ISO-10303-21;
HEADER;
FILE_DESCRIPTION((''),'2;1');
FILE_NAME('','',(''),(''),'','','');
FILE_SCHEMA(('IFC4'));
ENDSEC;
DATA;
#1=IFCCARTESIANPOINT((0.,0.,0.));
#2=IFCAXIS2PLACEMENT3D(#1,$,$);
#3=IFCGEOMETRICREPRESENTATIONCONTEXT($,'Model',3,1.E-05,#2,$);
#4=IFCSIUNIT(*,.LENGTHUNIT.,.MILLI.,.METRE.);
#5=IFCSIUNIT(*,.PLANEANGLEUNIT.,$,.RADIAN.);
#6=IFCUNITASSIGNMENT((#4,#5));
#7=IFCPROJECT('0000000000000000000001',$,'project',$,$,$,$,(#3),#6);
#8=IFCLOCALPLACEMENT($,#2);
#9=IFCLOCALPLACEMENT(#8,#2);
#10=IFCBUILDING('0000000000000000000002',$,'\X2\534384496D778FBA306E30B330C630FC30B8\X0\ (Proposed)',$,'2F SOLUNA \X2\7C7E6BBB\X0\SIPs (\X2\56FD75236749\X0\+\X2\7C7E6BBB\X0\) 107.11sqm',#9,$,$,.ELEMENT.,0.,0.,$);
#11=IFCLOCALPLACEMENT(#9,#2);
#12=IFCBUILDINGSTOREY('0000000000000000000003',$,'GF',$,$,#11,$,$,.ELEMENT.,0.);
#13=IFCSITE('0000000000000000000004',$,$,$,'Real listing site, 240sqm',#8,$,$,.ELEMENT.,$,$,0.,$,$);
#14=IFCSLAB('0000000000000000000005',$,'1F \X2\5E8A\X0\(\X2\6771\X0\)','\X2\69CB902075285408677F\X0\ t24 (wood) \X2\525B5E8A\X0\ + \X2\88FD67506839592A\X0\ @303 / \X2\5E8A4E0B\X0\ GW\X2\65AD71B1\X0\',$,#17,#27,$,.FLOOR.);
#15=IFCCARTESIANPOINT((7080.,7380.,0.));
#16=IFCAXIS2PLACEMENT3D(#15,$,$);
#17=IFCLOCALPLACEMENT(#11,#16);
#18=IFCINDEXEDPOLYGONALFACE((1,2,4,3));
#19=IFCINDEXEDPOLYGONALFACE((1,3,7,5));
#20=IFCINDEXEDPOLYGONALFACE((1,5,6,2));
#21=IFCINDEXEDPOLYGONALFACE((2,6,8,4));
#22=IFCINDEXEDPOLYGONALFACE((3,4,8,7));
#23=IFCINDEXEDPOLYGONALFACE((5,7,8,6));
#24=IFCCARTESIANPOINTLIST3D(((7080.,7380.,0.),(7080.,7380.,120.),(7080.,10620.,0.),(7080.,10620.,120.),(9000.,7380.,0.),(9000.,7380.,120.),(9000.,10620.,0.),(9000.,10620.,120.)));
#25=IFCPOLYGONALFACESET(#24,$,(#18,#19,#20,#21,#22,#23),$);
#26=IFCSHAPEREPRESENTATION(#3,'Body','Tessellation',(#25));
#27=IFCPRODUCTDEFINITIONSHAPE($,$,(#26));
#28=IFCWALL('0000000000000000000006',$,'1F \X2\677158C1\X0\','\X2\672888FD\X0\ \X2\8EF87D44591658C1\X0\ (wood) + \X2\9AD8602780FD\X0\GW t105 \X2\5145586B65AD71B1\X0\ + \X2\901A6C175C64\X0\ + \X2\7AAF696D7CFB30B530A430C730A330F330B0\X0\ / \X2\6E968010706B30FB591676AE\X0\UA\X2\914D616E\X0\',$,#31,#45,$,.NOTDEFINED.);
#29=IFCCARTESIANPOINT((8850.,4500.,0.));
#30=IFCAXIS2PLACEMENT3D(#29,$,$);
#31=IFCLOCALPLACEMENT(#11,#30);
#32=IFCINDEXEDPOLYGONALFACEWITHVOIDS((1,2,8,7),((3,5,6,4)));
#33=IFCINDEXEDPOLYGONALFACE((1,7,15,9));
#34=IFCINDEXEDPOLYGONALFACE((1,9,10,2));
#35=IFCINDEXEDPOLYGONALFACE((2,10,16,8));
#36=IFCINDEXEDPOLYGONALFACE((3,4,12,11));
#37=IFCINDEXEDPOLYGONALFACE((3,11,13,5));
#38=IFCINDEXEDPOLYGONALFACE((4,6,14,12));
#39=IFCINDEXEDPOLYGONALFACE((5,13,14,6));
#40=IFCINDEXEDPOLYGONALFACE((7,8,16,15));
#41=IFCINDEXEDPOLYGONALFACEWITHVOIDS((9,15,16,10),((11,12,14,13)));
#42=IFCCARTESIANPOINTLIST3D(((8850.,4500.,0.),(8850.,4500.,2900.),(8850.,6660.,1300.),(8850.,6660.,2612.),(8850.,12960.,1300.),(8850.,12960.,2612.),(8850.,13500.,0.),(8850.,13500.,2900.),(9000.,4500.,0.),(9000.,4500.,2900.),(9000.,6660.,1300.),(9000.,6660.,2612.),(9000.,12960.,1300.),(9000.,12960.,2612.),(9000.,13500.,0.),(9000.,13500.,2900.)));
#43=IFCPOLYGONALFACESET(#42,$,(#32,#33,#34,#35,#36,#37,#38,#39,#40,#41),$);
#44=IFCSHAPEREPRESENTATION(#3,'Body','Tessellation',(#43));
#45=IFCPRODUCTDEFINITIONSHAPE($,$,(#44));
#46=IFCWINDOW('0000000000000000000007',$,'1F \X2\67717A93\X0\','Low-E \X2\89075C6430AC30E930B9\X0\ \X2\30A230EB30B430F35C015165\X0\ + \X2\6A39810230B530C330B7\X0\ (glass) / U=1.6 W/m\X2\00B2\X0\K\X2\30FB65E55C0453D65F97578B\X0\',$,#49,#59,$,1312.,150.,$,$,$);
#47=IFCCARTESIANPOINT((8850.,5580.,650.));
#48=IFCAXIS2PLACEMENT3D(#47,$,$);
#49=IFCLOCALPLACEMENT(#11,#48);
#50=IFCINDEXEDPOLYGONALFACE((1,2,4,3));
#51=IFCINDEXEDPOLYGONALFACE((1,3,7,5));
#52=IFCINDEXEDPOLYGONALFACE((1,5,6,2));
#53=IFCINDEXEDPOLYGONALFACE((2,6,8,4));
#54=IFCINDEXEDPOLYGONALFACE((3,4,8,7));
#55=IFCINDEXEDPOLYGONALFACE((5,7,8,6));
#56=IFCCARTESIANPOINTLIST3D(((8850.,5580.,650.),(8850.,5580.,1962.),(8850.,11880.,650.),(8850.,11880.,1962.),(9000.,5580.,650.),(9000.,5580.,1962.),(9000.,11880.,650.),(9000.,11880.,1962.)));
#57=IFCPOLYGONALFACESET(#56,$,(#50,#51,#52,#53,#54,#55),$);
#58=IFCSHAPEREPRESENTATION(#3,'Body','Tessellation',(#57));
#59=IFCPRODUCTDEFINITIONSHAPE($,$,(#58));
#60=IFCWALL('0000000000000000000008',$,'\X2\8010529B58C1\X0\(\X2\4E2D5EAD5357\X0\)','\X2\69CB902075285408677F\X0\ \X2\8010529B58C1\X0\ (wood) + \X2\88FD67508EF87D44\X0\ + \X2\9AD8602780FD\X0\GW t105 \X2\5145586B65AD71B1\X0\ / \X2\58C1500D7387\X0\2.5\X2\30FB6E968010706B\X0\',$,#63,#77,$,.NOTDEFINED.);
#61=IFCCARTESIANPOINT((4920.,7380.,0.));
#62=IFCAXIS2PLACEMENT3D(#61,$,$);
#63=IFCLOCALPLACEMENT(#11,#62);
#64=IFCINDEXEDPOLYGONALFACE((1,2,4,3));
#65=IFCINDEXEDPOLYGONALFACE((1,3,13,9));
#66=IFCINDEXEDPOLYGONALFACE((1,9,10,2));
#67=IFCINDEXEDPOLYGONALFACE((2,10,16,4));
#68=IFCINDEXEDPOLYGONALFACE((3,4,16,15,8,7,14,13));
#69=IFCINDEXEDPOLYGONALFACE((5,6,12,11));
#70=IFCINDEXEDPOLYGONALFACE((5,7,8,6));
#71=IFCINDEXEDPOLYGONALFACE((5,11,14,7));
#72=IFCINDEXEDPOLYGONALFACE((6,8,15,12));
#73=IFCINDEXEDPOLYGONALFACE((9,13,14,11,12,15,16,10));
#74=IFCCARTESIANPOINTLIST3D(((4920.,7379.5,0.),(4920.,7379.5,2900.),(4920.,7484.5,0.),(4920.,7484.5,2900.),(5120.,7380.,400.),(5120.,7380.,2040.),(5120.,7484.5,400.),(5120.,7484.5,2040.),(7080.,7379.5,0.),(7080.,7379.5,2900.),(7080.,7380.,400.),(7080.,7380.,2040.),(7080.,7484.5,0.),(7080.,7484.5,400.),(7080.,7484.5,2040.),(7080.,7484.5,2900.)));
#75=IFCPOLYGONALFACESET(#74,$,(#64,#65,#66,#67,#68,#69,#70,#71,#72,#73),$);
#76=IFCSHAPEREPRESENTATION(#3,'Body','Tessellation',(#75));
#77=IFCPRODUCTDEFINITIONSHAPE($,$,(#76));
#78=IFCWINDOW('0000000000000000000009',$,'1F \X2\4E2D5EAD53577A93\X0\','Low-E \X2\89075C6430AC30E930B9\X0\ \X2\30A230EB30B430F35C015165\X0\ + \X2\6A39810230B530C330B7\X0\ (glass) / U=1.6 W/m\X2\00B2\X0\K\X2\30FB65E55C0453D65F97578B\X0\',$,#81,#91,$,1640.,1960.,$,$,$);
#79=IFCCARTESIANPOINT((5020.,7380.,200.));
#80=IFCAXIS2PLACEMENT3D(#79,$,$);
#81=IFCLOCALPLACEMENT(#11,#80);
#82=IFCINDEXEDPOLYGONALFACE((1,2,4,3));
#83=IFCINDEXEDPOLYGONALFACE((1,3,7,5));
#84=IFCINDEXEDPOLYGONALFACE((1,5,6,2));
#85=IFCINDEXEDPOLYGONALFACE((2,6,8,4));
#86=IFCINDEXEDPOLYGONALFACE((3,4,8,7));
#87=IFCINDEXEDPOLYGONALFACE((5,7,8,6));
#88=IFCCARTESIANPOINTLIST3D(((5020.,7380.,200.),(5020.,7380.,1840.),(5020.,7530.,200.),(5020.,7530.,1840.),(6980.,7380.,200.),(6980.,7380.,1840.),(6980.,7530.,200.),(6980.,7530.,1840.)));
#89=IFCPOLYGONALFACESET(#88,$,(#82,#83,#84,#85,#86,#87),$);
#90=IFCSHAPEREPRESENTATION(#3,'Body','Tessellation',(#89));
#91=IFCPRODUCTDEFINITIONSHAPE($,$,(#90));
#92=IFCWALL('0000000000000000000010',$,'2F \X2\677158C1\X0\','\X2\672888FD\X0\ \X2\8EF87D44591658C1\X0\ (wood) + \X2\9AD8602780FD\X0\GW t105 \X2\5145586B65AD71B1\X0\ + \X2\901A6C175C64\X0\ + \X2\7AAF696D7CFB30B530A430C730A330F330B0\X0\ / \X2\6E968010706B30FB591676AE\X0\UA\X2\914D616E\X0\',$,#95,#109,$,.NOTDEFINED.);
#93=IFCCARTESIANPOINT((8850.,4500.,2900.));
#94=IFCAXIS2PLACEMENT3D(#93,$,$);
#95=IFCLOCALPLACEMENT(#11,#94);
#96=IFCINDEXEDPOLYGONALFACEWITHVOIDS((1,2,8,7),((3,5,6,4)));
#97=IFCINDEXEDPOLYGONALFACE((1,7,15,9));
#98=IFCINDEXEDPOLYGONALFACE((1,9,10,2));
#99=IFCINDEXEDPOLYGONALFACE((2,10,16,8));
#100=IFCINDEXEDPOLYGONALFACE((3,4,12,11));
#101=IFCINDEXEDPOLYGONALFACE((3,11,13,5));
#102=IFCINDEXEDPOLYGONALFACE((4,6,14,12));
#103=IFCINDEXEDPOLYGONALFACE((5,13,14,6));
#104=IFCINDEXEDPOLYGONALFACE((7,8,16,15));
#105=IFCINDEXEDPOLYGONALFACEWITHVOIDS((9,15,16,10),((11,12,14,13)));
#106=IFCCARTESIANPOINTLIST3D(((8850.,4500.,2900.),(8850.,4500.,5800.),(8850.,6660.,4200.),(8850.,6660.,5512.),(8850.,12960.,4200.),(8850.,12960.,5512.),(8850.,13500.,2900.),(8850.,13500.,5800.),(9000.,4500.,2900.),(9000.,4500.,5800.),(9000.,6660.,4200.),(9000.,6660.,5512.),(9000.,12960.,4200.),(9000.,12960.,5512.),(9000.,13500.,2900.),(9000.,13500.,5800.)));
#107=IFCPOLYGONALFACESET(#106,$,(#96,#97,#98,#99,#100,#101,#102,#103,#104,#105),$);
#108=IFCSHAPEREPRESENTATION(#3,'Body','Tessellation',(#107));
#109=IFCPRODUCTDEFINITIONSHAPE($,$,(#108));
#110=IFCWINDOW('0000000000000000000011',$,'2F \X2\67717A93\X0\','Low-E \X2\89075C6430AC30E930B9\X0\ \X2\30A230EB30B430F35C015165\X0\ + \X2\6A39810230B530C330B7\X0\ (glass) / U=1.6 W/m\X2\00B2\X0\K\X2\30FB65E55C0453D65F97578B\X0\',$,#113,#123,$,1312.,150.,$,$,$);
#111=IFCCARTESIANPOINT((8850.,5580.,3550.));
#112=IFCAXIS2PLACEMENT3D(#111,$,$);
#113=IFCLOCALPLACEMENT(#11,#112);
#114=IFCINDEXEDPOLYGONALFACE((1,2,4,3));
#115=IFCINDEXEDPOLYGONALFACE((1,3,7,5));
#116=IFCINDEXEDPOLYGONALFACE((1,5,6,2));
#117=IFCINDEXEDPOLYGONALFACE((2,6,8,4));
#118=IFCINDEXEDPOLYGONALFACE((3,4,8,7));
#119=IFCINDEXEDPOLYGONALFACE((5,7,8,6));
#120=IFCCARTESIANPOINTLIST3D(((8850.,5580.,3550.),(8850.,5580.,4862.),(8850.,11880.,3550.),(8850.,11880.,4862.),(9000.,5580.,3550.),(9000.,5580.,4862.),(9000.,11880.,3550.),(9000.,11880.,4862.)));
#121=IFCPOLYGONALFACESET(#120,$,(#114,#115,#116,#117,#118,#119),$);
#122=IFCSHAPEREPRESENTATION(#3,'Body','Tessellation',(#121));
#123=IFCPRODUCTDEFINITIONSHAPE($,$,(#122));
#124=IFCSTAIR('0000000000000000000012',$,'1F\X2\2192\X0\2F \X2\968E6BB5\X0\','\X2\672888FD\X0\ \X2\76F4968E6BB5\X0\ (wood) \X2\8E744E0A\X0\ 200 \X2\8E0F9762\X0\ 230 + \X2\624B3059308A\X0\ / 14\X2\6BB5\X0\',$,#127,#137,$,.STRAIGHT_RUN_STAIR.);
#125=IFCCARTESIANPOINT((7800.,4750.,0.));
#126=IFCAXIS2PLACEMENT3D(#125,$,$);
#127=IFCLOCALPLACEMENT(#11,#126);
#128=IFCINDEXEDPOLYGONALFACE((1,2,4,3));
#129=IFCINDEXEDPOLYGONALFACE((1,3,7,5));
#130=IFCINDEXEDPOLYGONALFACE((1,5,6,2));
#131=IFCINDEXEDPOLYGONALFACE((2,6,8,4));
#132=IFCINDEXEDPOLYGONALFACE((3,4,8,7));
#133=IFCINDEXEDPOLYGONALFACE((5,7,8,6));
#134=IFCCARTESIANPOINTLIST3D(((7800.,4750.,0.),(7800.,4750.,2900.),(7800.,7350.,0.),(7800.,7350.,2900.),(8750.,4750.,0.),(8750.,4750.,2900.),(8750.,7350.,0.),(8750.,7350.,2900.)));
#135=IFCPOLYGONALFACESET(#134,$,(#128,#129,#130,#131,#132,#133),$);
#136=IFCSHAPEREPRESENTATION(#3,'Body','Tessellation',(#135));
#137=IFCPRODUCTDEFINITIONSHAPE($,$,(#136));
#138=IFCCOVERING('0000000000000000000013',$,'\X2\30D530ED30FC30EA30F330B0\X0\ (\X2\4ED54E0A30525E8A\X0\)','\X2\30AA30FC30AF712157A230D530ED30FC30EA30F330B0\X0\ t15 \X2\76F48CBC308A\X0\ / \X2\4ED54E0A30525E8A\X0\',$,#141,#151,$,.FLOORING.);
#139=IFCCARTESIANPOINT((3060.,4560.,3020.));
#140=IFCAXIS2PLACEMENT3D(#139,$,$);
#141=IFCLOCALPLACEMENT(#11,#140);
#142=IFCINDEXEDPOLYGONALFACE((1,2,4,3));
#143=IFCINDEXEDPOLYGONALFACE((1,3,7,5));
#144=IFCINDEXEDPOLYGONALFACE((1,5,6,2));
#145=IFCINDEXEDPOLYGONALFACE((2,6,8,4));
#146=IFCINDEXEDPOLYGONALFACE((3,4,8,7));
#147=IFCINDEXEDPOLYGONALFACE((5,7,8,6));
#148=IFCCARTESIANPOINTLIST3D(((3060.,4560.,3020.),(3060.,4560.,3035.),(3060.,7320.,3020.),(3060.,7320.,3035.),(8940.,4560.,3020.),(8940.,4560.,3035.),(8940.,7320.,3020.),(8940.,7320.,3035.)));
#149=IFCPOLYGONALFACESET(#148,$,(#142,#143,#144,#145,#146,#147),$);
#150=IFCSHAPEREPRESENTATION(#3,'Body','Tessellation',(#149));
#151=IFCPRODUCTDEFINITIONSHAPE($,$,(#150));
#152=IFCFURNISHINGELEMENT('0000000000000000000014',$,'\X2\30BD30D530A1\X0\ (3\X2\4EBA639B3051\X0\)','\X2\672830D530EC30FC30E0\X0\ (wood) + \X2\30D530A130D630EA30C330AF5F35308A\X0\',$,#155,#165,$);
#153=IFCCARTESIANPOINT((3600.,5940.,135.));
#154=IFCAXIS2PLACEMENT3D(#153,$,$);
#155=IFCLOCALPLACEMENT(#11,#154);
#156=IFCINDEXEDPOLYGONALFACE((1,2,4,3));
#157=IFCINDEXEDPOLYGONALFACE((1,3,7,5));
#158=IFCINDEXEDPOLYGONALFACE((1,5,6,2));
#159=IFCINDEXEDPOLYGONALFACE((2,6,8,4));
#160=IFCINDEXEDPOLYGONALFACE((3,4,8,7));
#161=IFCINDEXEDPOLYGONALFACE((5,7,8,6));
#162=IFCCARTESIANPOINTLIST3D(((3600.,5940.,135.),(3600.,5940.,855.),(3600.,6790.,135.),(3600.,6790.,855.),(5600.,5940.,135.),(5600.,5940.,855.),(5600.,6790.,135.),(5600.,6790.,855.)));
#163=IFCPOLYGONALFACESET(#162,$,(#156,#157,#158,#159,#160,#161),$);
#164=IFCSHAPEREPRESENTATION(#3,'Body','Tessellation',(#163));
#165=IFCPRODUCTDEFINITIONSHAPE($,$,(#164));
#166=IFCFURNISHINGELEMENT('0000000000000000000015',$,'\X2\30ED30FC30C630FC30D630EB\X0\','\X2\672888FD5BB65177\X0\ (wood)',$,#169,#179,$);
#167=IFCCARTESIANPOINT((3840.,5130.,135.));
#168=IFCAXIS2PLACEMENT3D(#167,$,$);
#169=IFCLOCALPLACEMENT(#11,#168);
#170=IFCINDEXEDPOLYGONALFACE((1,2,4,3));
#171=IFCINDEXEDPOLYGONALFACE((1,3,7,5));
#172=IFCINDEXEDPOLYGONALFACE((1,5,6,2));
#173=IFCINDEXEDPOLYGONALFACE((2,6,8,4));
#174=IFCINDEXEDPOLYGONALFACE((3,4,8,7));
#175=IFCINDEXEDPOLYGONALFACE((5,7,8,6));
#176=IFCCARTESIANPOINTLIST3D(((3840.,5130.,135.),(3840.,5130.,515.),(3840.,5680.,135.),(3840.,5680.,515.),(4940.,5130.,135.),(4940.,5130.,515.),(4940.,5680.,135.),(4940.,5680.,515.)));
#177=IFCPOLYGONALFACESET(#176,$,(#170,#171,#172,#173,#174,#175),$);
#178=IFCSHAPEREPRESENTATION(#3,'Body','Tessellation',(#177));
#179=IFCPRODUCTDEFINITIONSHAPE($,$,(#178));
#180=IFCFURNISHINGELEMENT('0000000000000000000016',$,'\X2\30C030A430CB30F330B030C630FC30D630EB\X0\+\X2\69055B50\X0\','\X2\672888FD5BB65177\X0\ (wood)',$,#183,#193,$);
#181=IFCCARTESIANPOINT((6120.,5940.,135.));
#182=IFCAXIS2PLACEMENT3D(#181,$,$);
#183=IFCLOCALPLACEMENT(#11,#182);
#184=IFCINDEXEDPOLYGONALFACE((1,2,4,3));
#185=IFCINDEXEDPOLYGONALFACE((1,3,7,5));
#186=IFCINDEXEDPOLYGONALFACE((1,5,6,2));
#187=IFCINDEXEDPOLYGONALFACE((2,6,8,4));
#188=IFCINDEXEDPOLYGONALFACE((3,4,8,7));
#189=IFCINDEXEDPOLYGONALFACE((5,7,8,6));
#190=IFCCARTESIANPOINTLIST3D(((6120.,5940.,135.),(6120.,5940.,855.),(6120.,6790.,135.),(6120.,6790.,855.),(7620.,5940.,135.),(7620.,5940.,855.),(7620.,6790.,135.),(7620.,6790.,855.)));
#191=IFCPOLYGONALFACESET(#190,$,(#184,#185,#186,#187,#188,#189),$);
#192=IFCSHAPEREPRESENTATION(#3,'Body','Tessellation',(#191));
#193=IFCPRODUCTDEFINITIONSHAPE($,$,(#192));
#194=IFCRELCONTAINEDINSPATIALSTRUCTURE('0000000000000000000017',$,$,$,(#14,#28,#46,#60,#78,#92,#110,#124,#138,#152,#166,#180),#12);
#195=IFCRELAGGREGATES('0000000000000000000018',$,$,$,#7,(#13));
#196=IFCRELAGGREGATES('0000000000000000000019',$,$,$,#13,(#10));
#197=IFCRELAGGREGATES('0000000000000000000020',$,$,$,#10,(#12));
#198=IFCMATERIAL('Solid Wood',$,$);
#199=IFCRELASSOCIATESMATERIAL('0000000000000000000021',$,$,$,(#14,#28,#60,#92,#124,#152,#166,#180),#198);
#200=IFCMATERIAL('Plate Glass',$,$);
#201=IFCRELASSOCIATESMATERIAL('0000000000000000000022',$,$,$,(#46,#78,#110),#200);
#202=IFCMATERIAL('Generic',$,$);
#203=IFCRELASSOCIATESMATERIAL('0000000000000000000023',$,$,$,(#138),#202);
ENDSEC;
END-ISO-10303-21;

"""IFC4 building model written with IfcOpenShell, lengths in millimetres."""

from ifc_helpers import new_model, si_unit, frame, frame_2d, origin, place, context, project, spatial, rectangle, extrude, material, element, fill, save


model = new_model("IFC4")

# Units and contexts
model_context = context("Model", 3, precision=1e-05, world=origin())
ifc_project = project(units=[si_unit("LENGTHUNIT", "METRE", prefix="MILLI"), si_unit("PLANEANGLEUNIT", "RADIAN")], contexts=[model_context])

# Site, building, storey
site_placement = place(None, origin())
site = spatial("IfcSite", under=ifc_project, at=site_placement, ObjectType="Real listing site, 240sqm", CompositionType="ELEMENT", RefElevation=0.0)
building_placement = place(site_placement, origin())
building = spatial("IfcBuilding", under=site, at=building_placement, Name="千葉海辺のコテージ (Proposed)", ObjectType="2F SOLUNA 籾殻SIPs (国産杉+籾殻) 107.11sqm", CompositionType="ELEMENT", ElevationOfRefHeight=0.0, ElevationOfTerrain=0.0)
storey_placement = place(building_placement, origin())
storey = spatial("IfcBuildingStorey", under=building, at=storey_placement, Name="GF", CompositionType="ELEMENT", Elevation=0.0)

# Slab
ifc_material_1 = material(Name="Solid Wood")
slab_placement = place(storey_placement, frame((7080.0, 7380.0, 0.0)))
element("IfcSlab", 1, at=slab_placement, inside=storey, material=ifc_material_1, Name="1F 床(東)", Description="構造用合板 t24 (wood) 剛床 + 製材根太 @303 / 床下 GW断熱", PredefinedType="FLOOR", context=model_context, shape_type="SweptSolid", body=[
    extrude(rectangle(XDim=1920.0, YDim=3240.0, at=frame_2d((960.0, 1620.0))), frame((7080.0, 7380.0, 0.0)), (0.0, 0.0, 1.0), 120.0),
])

# Walls, openings, windows
wall_1_placement = place(storey_placement, frame((8850.0, 4500.0, 0.0)))
wall_1 = element("IfcWall", 2, at=wall_1_placement, inside=storey, material=ifc_material_1, Name="1F 東壁", Description="木製 軸組外壁 (wood) + 高性能GW t105 充填断熱 + 通気層 + 窯業系サイディング / 準耐火・外皮UA配慮", PredefinedType="NOTDEFINED", context=model_context, shape_type="SweptSolid", body=[
    extrude(rectangle(XDim=150.0, YDim=9000.0, at=frame_2d((75.0, 4500.0))), frame((8850.0, 4500.0, 0.0)), (0.0, 0.0, 1.0), 2900.0),
])
opening_1_placement = place(storey_placement, frame((8850.0, 5580.0, 650.0)))
opening_1 = element("IfcOpeningElement", 3, at=opening_1_placement, cuts=wall_1, PredefinedType="NOTDEFINED", context=model_context, shape_type="SweptSolid", body=[
    extrude(rectangle(XDim=150.0, YDim=6300.0, at=frame_2d((75.0, 3150.0))), frame((8850.0, 5580.0, 650.0)), (0.0, 0.0, 1.0), 1312.0),
])
ifc_material_2 = material(Name="Plate Glass")
window_1_placement = place(storey_placement, frame((8850.0, 5580.0, 650.0)))
window_1 = element("IfcWindow", 4, at=window_1_placement, inside=storey, material=ifc_material_2, Name="1F 東窓", Description="Low-E 複層ガラス アルゴン封入 + 樹脂サッシ (glass) / U=1.6 W/m²K・日射取得型", OverallHeight=1312.0, OverallWidth=150.0, context=model_context, shape_type="SweptSolid", body=[
    extrude(rectangle(XDim=150.0, YDim=6300.0, at=frame_2d((75.0, 3150.0))), frame((8850.0, 5580.0, 650.0)), (0.0, 0.0, 1.0), 1312.0),
])
fill(opening_1, window_1)
wall_2_placement = place(storey_placement, frame((4920.0, 7380.0, 0.0)))
wall_2 = element("IfcWall", 5, at=wall_2_placement, inside=storey, material=ifc_material_1, Name="耐力壁(中庭南)", Description="構造用合板 耐力壁 (wood) + 製材軸組 + 高性能GW t105 充填断熱 / 壁倍率2.5・準耐火", PredefinedType="NOTDEFINED", context=model_context, shape_type="SweptSolid", body=[
    extrude(rectangle(XDim=2160.0, YDim=105.0, at=frame_2d((1080.0, 52.0))), frame((4920.0, 7380.0, 0.0)), (0.0, 0.0, 1.0), 2900.0),
])
opening_2_placement = place(storey_placement, frame((5020.0, 7380.0, 200.0)))
opening_2 = element("IfcOpeningElement", 6, at=opening_2_placement, cuts=wall_2, PredefinedType="NOTDEFINED", context=model_context, shape_type="SweptSolid", body=[
    extrude(rectangle(XDim=1960.0, YDim=150.0, at=frame_2d((980.0, 75.0))), frame((5020.0, 7380.0, 200.0)), (0.0, 0.0, 1.0), 1640.0),
])
window_2_placement = place(storey_placement, frame((5020.0, 7380.0, 200.0)))
window_2 = element("IfcWindow", 7, at=window_2_placement, inside=storey, material=ifc_material_2, Name="1F 中庭南窓", Description="Low-E 複層ガラス アルゴン封入 + 樹脂サッシ (glass) / U=1.6 W/m²K・日射取得型", OverallHeight=1640.0, OverallWidth=1960.0, context=model_context, shape_type="SweptSolid", body=[
    extrude(rectangle(XDim=1960.0, YDim=150.0, at=frame_2d((980.0, 75.0))), frame((5020.0, 7380.0, 200.0)), (0.0, 0.0, 1.0), 1640.0),
])
fill(opening_2, window_2)

# Wall, opening, window
wall_3_placement = place(storey_placement, frame((8850.0, 4500.0, 2900.0)))
wall_3 = element("IfcWall", 8, at=wall_3_placement, inside=storey, material=ifc_material_1, Name="2F 東壁", Description="木製 軸組外壁 (wood) + 高性能GW t105 充填断熱 + 通気層 + 窯業系サイディング / 準耐火・外皮UA配慮", PredefinedType="NOTDEFINED", context=model_context, shape_type="SweptSolid", body=[
    extrude(rectangle(XDim=150.0, YDim=9000.0, at=frame_2d((75.0, 4500.0))), frame((8850.0, 4500.0, 2900.0)), (0.0, 0.0, 1.0), 2900.0),
])
opening_3_placement = place(storey_placement, frame((8850.0, 5580.0, 3550.0)))
opening_3 = element("IfcOpeningElement", 9, at=opening_3_placement, cuts=wall_3, PredefinedType="NOTDEFINED", context=model_context, shape_type="SweptSolid", body=[
    extrude(rectangle(XDim=150.0, YDim=6300.0, at=frame_2d((75.0, 3150.0))), frame((8850.0, 5580.0, 3550.0)), (0.0, 0.0, 1.0), 1312.0),
])
window_3_placement = place(storey_placement, frame((8850.0, 5580.0, 3550.0)))
window_3 = element("IfcWindow", 10, at=window_3_placement, inside=storey, material=ifc_material_2, Name="2F 東窓", Description="Low-E 複層ガラス アルゴン封入 + 樹脂サッシ (glass) / U=1.6 W/m²K・日射取得型", OverallHeight=1312.0, OverallWidth=150.0, context=model_context, shape_type="SweptSolid", body=[
    extrude(rectangle(XDim=150.0, YDim=6300.0, at=frame_2d((75.0, 3150.0))), frame((8850.0, 5580.0, 3550.0)), (0.0, 0.0, 1.0), 1312.0),
])
fill(opening_3, window_3)

# Stair
stair_placement = place(storey_placement, frame((7800.0, 4750.0, 0.0)))
element("IfcStair", 11, at=stair_placement, inside=storey, material=ifc_material_1, Name="1F→2F 階段", Description="木製 直階段 (wood) 蹴上 200 踏面 230 + 手すり / 14段", PredefinedType="STRAIGHT_RUN_STAIR", context=model_context, shape_type="SweptSolid", body=[
    extrude(rectangle(XDim=950.0, YDim=2600.0, at=frame_2d((475.0, 1300.0))), frame((7800.0, 4750.0, 0.0)), (0.0, 0.0, 1.0), 2900.0),
])

# Covering
ifc_material_3 = material(Name="Generic")
covering_placement = place(storey_placement, frame((3060.0, 4560.0, 3020.0)))
element("IfcCovering", 12, at=covering_placement, inside=storey, material=ifc_material_3, Name="フローリング (仕上げ床)", Description="オーク無垢フローリング t15 直貼り / 仕上げ床", PredefinedType="FLOORING", context=model_context, shape_type="SweptSolid", body=[
    extrude(rectangle(XDim=5880.0, YDim=2760.0, at=frame_2d((2940.0, 1380.0))), frame((3060.0, 4560.0, 3020.0)), (0.0, 0.0, 1.0), 15.0),
])

# Furnishing elements
furnishing_1_placement = place(storey_placement, frame((3600.0, 5940.0, 135.0)))
element("IfcFurnishingElement", 13, at=furnishing_1_placement, inside=storey, material=ifc_material_1, Name="ソファ (3人掛け)", Description="木フレーム (wood) + ファブリック張り", context=model_context, shape_type="SweptSolid", body=[
    extrude(rectangle(XDim=2000.0, YDim=850.0, at=frame_2d((1000.0, 425.0))), frame((3600.0, 5940.0, 135.0)), (0.0, 0.0, 1.0), 720.0),
])
furnishing_2_placement = place(storey_placement, frame((3840.0, 5130.0, 135.0)))
element("IfcFurnishingElement", 14, at=furnishing_2_placement, inside=storey, material=ifc_material_1, Name="ローテーブル", Description="木製家具 (wood)", context=model_context, shape_type="SweptSolid", body=[
    extrude(rectangle(XDim=1100.0, YDim=550.0, at=frame_2d((550.0, 275.0))), frame((3840.0, 5130.0, 135.0)), (0.0, 0.0, 1.0), 380.0),
])
furnishing_3_placement = place(storey_placement, frame((6120.0, 5940.0, 135.0)))
element("IfcFurnishingElement", 15, at=furnishing_3_placement, inside=storey, material=ifc_material_1, Name="ダイニングテーブル+椅子", Description="木製家具 (wood)", context=model_context, shape_type="SweptSolid", body=[
    extrude(rectangle(XDim=1500.0, YDim=850.0, at=frame_2d((750.0, 425.0))), frame((6120.0, 5940.0, 135.0)), (0.0, 0.0, 1.0), 720.0),
])

save(model, "model.ifc")
